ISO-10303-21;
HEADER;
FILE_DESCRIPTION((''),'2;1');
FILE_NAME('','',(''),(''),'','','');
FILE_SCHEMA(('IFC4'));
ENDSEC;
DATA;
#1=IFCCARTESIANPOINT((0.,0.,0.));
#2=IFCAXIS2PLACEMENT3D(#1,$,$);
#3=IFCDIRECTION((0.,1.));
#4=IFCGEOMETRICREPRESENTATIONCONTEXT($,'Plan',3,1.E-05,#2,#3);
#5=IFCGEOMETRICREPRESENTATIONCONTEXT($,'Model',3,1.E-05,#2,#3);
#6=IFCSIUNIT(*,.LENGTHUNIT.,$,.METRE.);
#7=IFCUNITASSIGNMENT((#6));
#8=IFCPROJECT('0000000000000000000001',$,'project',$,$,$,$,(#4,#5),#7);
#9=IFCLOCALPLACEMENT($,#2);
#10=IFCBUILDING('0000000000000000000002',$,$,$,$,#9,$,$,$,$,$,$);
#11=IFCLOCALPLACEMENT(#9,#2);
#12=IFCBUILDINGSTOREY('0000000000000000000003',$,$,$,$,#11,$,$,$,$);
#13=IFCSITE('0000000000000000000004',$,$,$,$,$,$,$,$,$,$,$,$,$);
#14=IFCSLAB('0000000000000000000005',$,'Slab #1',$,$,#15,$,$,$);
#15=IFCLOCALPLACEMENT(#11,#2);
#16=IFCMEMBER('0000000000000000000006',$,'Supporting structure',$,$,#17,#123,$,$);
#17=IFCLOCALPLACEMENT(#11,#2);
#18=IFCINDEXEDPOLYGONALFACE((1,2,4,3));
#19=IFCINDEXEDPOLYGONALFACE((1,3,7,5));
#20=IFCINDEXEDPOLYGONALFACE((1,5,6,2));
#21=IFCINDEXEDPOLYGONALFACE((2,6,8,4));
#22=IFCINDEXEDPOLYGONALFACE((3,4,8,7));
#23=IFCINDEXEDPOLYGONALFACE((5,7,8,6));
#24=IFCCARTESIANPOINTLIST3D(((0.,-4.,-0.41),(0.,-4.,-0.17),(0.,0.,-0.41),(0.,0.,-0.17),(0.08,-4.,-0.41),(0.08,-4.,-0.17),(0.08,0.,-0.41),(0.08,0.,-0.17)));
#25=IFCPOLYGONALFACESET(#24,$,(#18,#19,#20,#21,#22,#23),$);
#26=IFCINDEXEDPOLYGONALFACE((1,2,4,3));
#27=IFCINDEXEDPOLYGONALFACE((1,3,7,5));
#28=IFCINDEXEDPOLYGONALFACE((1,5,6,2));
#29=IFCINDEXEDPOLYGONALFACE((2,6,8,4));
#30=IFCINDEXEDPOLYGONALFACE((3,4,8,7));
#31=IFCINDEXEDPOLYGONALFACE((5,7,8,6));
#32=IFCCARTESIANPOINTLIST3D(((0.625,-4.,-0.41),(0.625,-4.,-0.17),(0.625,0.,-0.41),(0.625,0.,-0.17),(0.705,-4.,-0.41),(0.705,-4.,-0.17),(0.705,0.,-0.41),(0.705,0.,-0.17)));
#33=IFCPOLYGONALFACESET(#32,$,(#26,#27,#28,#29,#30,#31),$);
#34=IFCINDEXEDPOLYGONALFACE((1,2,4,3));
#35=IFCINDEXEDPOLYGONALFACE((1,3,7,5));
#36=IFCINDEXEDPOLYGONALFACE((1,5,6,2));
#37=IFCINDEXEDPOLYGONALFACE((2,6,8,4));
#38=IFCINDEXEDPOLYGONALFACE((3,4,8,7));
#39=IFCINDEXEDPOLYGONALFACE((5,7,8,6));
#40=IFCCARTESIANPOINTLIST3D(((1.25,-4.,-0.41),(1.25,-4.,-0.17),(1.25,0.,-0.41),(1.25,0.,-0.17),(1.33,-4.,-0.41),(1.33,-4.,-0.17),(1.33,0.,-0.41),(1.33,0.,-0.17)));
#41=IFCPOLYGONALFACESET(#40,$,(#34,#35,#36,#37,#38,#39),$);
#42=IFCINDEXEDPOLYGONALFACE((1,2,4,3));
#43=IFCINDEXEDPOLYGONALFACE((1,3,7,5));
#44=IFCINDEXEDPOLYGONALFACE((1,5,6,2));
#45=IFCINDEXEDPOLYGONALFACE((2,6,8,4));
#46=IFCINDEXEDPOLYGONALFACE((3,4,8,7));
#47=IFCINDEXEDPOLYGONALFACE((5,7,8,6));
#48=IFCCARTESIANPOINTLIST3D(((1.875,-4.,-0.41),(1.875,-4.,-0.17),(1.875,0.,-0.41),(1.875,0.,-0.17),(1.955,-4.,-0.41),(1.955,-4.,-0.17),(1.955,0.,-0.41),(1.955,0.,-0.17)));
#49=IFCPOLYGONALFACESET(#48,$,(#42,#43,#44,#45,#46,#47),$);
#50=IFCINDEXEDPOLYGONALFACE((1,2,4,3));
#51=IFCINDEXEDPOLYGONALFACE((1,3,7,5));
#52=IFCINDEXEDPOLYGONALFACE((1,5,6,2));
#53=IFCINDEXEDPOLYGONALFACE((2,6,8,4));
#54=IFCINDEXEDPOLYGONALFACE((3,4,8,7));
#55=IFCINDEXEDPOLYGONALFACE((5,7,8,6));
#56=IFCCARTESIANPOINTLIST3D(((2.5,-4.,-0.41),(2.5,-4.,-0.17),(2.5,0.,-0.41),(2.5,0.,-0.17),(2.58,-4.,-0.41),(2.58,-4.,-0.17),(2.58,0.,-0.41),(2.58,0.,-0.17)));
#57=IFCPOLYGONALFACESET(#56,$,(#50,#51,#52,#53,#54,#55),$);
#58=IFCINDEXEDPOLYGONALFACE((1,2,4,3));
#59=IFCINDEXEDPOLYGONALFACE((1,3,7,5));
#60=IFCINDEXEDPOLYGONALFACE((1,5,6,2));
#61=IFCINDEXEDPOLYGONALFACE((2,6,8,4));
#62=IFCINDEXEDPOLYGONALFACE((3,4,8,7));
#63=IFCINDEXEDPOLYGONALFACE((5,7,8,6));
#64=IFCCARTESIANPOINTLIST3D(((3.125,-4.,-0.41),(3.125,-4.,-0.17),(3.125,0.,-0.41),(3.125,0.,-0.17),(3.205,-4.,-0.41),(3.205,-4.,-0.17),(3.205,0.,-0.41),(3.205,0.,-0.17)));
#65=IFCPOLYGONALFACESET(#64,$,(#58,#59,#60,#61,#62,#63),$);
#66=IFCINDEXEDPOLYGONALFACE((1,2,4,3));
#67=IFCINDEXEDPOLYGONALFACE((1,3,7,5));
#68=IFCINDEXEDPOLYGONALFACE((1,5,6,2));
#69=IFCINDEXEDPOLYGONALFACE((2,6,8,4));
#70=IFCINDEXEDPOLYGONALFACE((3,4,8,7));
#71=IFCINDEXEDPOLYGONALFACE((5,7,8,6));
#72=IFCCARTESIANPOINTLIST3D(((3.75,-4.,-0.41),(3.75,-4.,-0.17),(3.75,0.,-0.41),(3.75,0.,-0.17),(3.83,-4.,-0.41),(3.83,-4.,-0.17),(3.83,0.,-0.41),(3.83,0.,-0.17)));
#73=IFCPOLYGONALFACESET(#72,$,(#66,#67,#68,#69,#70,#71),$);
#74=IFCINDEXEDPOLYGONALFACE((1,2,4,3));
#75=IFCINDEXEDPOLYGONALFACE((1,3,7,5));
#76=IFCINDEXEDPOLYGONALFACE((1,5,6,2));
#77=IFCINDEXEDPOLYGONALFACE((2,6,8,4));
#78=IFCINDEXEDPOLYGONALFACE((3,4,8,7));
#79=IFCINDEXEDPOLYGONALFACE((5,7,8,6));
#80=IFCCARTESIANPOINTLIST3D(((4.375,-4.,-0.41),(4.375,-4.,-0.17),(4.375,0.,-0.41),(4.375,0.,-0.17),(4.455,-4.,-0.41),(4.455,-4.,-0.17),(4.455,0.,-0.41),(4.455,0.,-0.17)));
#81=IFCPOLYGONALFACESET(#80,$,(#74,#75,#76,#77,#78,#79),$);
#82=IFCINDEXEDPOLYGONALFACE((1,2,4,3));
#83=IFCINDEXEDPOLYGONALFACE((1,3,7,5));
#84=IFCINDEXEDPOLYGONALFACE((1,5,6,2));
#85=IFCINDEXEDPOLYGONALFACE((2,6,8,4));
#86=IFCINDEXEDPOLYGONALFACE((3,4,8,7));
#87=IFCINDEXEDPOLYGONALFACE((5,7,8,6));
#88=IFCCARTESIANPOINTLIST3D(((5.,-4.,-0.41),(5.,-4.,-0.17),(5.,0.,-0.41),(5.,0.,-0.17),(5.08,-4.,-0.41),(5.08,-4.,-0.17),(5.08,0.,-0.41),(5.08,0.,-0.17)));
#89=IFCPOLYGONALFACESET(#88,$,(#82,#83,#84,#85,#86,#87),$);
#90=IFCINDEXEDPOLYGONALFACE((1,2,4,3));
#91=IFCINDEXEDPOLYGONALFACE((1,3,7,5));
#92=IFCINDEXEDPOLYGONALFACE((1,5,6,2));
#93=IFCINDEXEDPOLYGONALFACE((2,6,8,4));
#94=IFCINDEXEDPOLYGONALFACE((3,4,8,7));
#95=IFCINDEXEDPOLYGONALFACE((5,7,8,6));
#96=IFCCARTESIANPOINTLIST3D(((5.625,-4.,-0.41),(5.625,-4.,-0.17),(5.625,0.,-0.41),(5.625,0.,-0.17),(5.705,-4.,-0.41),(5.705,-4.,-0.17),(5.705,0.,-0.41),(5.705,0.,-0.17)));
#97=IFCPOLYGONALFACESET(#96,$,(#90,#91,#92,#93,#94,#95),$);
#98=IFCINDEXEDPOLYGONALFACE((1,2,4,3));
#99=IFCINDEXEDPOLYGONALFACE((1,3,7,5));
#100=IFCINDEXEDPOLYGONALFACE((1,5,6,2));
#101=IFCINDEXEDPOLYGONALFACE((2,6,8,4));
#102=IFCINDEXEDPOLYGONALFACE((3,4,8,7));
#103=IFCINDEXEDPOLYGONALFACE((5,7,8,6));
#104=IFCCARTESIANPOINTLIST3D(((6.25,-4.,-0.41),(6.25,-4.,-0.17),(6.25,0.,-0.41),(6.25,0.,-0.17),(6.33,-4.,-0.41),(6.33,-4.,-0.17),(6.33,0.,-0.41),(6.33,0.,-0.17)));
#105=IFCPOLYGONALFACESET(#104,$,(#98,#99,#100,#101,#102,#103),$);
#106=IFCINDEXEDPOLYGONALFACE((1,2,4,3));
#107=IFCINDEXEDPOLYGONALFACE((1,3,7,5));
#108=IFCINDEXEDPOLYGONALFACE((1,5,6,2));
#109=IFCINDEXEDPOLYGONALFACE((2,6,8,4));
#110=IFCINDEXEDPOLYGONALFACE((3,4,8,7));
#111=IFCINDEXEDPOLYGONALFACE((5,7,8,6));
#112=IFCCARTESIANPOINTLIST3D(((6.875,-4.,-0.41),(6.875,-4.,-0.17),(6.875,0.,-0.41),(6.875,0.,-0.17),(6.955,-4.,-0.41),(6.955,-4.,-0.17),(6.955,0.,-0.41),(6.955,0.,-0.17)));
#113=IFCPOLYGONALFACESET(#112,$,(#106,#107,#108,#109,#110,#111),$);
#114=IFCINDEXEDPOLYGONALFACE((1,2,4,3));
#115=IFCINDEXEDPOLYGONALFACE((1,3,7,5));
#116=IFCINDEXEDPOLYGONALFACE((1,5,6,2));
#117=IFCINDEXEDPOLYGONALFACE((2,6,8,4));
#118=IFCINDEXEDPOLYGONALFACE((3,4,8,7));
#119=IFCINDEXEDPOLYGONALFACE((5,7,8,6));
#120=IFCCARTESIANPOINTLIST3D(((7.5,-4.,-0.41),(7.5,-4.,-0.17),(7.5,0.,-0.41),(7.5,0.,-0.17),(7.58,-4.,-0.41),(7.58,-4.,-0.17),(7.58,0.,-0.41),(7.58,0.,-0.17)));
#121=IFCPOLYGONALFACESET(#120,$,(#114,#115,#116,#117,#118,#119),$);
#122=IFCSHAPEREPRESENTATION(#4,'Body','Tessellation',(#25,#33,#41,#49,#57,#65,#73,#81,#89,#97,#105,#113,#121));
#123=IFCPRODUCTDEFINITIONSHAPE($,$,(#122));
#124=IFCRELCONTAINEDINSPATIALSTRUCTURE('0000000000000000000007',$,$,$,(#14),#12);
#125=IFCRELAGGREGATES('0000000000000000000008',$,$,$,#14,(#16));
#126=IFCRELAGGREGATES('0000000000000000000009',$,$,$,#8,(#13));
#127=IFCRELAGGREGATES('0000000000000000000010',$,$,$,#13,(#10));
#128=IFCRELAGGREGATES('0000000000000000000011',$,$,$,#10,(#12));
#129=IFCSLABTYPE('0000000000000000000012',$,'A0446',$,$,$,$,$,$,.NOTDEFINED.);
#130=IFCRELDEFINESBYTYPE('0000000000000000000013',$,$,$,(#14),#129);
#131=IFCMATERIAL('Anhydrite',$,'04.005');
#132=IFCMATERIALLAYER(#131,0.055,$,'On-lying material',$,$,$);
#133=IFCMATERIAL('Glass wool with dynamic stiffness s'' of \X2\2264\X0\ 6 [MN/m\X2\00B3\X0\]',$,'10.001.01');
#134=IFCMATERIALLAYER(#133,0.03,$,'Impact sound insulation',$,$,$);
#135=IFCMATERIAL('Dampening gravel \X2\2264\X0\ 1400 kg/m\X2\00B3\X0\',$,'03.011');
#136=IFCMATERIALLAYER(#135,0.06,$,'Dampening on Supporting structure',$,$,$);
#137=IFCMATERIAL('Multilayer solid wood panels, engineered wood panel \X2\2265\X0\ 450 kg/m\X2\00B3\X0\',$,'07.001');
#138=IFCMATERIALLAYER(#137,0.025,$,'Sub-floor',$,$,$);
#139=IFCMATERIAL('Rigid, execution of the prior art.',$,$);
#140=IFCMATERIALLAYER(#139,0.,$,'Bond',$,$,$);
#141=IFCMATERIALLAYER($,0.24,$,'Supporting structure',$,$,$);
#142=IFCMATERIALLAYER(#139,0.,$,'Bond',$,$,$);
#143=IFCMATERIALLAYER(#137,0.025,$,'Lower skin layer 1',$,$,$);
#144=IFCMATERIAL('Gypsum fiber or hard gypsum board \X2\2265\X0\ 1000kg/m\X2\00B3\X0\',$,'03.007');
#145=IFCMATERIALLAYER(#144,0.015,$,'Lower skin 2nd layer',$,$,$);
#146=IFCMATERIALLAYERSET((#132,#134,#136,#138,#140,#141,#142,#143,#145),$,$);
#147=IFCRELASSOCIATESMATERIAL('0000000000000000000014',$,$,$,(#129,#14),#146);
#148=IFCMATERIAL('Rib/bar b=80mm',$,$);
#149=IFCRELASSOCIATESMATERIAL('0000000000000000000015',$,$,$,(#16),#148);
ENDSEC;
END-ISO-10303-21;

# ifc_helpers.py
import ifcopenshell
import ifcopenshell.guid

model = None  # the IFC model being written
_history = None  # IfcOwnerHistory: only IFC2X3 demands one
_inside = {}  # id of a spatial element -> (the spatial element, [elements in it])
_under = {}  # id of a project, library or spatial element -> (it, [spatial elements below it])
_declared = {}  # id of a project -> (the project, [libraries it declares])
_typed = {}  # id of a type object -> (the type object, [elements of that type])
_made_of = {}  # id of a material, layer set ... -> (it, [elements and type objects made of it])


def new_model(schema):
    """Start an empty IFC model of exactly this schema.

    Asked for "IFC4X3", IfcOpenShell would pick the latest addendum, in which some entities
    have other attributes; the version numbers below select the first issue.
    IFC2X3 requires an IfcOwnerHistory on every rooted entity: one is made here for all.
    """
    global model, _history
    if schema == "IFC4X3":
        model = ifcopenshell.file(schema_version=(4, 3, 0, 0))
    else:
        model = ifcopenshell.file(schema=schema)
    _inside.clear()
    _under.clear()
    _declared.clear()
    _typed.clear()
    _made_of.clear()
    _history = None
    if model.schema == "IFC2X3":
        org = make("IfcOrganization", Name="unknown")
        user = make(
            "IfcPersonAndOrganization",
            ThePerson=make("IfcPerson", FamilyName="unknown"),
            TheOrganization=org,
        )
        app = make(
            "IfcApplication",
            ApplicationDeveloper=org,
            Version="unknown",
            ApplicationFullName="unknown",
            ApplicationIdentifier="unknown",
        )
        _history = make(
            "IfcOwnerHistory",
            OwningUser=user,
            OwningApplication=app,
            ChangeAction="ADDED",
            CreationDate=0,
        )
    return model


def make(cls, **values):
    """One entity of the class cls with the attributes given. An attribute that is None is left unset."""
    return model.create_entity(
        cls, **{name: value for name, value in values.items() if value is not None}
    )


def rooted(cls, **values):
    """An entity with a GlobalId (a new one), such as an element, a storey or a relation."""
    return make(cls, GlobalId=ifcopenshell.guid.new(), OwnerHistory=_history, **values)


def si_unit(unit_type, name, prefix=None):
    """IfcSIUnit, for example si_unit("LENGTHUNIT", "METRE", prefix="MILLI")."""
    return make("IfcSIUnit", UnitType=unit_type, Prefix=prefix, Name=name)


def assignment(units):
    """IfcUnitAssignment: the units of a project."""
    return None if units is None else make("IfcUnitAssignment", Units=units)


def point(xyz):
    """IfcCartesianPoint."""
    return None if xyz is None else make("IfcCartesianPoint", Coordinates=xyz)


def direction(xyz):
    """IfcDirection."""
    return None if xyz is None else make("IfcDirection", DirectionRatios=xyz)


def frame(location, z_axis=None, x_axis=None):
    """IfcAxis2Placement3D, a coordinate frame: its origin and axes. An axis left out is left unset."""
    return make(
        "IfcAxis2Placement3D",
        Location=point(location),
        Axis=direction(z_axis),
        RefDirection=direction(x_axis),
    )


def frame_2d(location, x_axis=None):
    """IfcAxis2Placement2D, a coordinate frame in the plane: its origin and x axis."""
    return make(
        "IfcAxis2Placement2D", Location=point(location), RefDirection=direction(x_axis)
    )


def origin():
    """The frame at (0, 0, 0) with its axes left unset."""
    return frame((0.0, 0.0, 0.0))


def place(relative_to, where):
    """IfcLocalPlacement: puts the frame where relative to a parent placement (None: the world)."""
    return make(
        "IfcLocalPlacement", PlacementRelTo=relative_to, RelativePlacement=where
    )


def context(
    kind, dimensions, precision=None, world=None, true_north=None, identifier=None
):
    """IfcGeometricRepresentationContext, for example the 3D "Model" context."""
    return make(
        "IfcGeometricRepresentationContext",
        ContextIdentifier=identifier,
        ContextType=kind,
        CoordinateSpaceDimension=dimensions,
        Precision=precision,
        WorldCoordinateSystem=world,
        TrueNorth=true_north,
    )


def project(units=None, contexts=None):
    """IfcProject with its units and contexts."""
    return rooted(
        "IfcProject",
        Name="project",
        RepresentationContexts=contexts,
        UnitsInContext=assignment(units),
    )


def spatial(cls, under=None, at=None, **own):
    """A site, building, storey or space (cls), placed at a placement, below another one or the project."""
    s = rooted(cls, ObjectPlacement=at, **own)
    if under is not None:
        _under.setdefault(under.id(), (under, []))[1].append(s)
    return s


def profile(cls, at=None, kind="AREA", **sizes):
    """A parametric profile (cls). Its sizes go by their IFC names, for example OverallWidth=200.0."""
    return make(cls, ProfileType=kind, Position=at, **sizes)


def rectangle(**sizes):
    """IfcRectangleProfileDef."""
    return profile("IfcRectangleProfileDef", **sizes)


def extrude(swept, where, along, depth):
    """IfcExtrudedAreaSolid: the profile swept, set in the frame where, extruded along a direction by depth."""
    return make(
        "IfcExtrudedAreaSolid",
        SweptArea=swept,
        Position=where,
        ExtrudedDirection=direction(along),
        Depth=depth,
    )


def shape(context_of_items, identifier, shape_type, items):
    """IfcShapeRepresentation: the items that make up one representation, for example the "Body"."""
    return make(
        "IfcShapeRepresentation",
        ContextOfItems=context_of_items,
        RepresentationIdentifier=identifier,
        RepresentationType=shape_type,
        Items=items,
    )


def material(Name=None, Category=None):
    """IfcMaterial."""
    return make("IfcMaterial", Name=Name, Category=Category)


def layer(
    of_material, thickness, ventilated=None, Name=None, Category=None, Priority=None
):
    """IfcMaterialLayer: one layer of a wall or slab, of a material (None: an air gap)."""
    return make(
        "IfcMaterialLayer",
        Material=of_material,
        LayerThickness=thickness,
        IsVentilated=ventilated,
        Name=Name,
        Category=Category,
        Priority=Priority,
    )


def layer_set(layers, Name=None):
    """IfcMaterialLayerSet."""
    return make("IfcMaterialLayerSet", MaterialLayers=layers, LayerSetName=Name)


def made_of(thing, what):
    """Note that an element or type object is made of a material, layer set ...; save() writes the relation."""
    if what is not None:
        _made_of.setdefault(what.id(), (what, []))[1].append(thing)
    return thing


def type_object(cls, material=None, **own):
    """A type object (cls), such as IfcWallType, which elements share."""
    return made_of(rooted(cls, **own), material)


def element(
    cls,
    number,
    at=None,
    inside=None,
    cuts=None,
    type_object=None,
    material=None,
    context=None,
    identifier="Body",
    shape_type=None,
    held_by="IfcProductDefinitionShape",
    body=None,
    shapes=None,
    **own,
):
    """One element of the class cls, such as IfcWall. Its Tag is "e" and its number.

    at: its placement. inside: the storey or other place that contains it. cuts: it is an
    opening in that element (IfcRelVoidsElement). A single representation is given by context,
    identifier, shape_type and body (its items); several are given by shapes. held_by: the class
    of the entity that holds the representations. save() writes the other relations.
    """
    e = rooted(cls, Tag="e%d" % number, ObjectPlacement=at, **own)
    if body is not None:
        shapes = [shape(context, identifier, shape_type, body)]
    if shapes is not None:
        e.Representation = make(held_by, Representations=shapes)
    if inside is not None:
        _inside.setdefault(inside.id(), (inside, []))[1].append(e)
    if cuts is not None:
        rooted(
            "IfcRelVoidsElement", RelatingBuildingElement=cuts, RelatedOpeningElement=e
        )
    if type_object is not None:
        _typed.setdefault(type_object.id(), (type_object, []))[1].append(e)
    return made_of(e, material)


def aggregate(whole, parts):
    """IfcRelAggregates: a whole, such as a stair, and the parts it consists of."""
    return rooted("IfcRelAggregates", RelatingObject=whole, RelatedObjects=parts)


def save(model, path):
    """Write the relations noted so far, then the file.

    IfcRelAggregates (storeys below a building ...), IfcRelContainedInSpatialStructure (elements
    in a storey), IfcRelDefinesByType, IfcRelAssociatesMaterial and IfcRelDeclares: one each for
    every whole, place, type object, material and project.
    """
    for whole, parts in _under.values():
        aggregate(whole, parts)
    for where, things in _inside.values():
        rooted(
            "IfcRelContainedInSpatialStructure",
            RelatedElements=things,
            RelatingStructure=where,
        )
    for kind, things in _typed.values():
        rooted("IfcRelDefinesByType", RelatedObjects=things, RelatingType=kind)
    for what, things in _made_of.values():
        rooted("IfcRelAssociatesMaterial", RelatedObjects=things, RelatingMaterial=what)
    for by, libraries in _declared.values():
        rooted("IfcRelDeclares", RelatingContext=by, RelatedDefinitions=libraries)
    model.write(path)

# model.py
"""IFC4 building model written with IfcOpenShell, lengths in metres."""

from ifc_helpers import new_model, si_unit, direction, frame, frame_2d, origin, place, context, project, spatial, rectangle, extrude, material, layer, layer_set, type_object, element, aggregate, save


model = new_model("IFC4")

# Units and contexts
plan_context = context("Plan", 3, precision=1e-05, world=origin(), true_north=direction((0.0, 1.0)))
model_context = context("Model", 3, precision=1e-05, world=origin(), true_north=direction((0.0, 1.0)))
ifc_project = project(units=[si_unit("LENGTHUNIT", "METRE")], contexts=[plan_context, model_context])

# Site, building, storey
site = spatial("IfcSite", under=ifc_project)
building_placement = place(None, origin())
building = spatial("IfcBuilding", under=site, at=building_placement)
storey_placement = place(building_placement, origin())
storey = spatial("IfcBuildingStorey", under=building, at=storey_placement)

# Slab, member
ifc_material_1 = material(Name="Anhydrite", Category="04.005")
ifc_layer_1 = layer(ifc_material_1, 0.055, Name="On-lying material")
ifc_material_2 = material(Name="Glass wool with dynamic stiffness s' of ≤ 6 [MN/m³]", Category="10.001.01")
ifc_layer_2 = layer(ifc_material_2, 0.03, Name="Impact sound insulation")
ifc_material_3 = material(Name="Dampening gravel ≤ 1400 kg/m³", Category="03.011")
ifc_layer_3 = layer(ifc_material_3, 0.06, Name="Dampening on Supporting structure")
ifc_material_4 = material(Name="Multilayer solid wood panels, engineered wood panel ≥ 450 kg/m³", Category="07.001")
ifc_layer_4 = layer(ifc_material_4, 0.025, Name="Sub-floor")
ifc_material_5 = material(Name="Rigid, execution of the prior art.")
ifc_layer_5 = layer(ifc_material_5, 0.0, Name="Bond")
ifc_layer_6 = layer(None, 0.24, Name="Supporting structure")
ifc_layer_7 = layer(ifc_material_5, 0.0, Name="Bond")
ifc_layer_8 = layer(ifc_material_4, 0.025, Name="Lower skin layer 1")
ifc_material_6 = material(Name="Gypsum fiber or hard gypsum board ≥ 1000kg/m³", Category="03.007")
ifc_layer_9 = layer(ifc_material_6, 0.015, Name="Lower skin 2nd layer")
ifc_layer_set = layer_set([ifc_layer_1, ifc_layer_2, ifc_layer_3, ifc_layer_4, ifc_layer_5, ifc_layer_6, ifc_layer_7, ifc_layer_8, ifc_layer_9])
slab_type = type_object("IfcSlabType", Name="A0446", PredefinedType="NOTDEFINED", material=ifc_layer_set)
slab_placement = place(None, frame((0.0, 0.0, 0.0), z_axis=(0.0, 0.0, -1.0), x_axis=(1.0, 0.0, 0.0)))
slab = element("IfcSlab", 1, at=slab_placement, inside=storey, type_object=slab_type, material=ifc_layer_set, Name="Slab #1")
ifc_material_7 = material(Name="Rib/bar b=80mm")
member_1_placement = place(slab_placement, origin())
member_1 = element("IfcMember", 2, at=member_1_placement, material=ifc_material_7, Name="Supporting structure", context=plan_context, shape_type="SweptSolid", body=[
    extrude(rectangle(XDim=0.08, YDim=0.24, at=frame_2d((0.04, 0.12), x_axis=(1.0, 0.0))), frame((0.0, 4.0, 0.17), z_axis=(0.0, -1.0, 0.0), x_axis=(1.0, 0.0, 0.0)), (0.0, 0.0, 1.0), 4.0),
    extrude(rectangle(XDim=0.08, YDim=0.24, at=frame_2d((0.04, 0.12), x_axis=(1.0, 0.0))), frame((0.625, 4.0, 0.17), z_axis=(0.0, -1.0, 0.0), x_axis=(1.0, 0.0, 0.0)), (0.0, 0.0, 1.0), 4.0),
    extrude(rectangle(XDim=0.08, YDim=0.24, at=frame_2d((0.04, 0.12), x_axis=(1.0, 0.0))), frame((1.25, 4.0, 0.17), z_axis=(0.0, -1.0, 0.0), x_axis=(1.0, 0.0, 0.0)), (0.0, 0.0, 1.0), 4.0),
    extrude(rectangle(XDim=0.08, YDim=0.24, at=frame_2d((0.04, 0.12), x_axis=(1.0, 0.0))), frame((1.875, 4.0, 0.17), z_axis=(0.0, -1.0, 0.0), x_axis=(1.0, 0.0, 0.0)), (0.0, 0.0, 1.0), 4.0),
    extrude(rectangle(XDim=0.08, YDim=0.24, at=frame_2d((0.04, 0.12), x_axis=(1.0, 0.0))), frame((2.5, 4.0, 0.17), z_axis=(0.0, -1.0, 0.0), x_axis=(1.0, 0.0, 0.0)), (0.0, 0.0, 1.0), 4.0),
    extrude(rectangle(XDim=0.08, YDim=0.24, at=frame_2d((0.04, 0.12), x_axis=(1.0, 0.0))), frame((3.125, 4.0, 0.17), z_axis=(0.0, -1.0, 0.0), x_axis=(1.0, 0.0, 0.0)), (0.0, 0.0, 1.0), 4.0),
    extrude(rectangle(XDim=0.08, YDim=0.24, at=frame_2d((0.04, 0.12), x_axis=(1.0, 0.0))), frame((3.75, 4.0, 0.17), z_axis=(0.0, -1.0, 0.0), x_axis=(1.0, 0.0, 0.0)), (0.0, 0.0, 1.0), 4.0),
    extrude(rectangle(XDim=0.08, YDim=0.24, at=frame_2d((0.04, 0.12), x_axis=(1.0, 0.0))), frame((4.375, 4.0, 0.17), z_axis=(0.0, -1.0, 0.0), x_axis=(1.0, 0.0, 0.0)), (0.0, 0.0, 1.0), 4.0),
    extrude(rectangle(XDim=0.08, YDim=0.24, at=frame_2d((0.04, 0.12), x_axis=(1.0, 0.0))), frame((5.0, 4.0, 0.17), z_axis=(0.0, -1.0, 0.0), x_axis=(1.0, 0.0, 0.0)), (0.0, 0.0, 1.0), 4.0),
    extrude(rectangle(XDim=0.08, YDim=0.24, at=frame_2d((0.04, 0.12), x_axis=(1.0, 0.0))), frame((5.625, 4.0, 0.17), z_axis=(0.0, -1.0, 0.0), x_axis=(1.0, 0.0, 0.0)), (0.0, 0.0, 1.0), 4.0),
    extrude(rectangle(XDim=0.08, YDim=0.24, at=frame_2d((0.04, 0.12), x_axis=(1.0, 0.0))), frame((6.25, 4.0, 0.17), z_axis=(0.0, -1.0, 0.0), x_axis=(1.0, 0.0, 0.0)), (0.0, 0.0, 1.0), 4.0),
    extrude(rectangle(XDim=0.08, YDim=0.24, at=frame_2d((0.04, 0.12), x_axis=(1.0, 0.0))), frame((6.875, 4.0, 0.17), z_axis=(0.0, -1.0, 0.0), x_axis=(1.0, 0.0, 0.0)), (0.0, 0.0, 1.0), 4.0),
    extrude(rectangle(XDim=0.08, YDim=0.24, at=frame_2d((0.04, 0.12), x_axis=(1.0, 0.0))), frame((7.5, 4.0, 0.17), z_axis=(0.0, -1.0, 0.0), x_axis=(1.0, 0.0, 0.0)), (0.0, 0.0, 1.0), 4.0),
])
aggregate(slab, [member_1])

save(model, "model.ifc")
